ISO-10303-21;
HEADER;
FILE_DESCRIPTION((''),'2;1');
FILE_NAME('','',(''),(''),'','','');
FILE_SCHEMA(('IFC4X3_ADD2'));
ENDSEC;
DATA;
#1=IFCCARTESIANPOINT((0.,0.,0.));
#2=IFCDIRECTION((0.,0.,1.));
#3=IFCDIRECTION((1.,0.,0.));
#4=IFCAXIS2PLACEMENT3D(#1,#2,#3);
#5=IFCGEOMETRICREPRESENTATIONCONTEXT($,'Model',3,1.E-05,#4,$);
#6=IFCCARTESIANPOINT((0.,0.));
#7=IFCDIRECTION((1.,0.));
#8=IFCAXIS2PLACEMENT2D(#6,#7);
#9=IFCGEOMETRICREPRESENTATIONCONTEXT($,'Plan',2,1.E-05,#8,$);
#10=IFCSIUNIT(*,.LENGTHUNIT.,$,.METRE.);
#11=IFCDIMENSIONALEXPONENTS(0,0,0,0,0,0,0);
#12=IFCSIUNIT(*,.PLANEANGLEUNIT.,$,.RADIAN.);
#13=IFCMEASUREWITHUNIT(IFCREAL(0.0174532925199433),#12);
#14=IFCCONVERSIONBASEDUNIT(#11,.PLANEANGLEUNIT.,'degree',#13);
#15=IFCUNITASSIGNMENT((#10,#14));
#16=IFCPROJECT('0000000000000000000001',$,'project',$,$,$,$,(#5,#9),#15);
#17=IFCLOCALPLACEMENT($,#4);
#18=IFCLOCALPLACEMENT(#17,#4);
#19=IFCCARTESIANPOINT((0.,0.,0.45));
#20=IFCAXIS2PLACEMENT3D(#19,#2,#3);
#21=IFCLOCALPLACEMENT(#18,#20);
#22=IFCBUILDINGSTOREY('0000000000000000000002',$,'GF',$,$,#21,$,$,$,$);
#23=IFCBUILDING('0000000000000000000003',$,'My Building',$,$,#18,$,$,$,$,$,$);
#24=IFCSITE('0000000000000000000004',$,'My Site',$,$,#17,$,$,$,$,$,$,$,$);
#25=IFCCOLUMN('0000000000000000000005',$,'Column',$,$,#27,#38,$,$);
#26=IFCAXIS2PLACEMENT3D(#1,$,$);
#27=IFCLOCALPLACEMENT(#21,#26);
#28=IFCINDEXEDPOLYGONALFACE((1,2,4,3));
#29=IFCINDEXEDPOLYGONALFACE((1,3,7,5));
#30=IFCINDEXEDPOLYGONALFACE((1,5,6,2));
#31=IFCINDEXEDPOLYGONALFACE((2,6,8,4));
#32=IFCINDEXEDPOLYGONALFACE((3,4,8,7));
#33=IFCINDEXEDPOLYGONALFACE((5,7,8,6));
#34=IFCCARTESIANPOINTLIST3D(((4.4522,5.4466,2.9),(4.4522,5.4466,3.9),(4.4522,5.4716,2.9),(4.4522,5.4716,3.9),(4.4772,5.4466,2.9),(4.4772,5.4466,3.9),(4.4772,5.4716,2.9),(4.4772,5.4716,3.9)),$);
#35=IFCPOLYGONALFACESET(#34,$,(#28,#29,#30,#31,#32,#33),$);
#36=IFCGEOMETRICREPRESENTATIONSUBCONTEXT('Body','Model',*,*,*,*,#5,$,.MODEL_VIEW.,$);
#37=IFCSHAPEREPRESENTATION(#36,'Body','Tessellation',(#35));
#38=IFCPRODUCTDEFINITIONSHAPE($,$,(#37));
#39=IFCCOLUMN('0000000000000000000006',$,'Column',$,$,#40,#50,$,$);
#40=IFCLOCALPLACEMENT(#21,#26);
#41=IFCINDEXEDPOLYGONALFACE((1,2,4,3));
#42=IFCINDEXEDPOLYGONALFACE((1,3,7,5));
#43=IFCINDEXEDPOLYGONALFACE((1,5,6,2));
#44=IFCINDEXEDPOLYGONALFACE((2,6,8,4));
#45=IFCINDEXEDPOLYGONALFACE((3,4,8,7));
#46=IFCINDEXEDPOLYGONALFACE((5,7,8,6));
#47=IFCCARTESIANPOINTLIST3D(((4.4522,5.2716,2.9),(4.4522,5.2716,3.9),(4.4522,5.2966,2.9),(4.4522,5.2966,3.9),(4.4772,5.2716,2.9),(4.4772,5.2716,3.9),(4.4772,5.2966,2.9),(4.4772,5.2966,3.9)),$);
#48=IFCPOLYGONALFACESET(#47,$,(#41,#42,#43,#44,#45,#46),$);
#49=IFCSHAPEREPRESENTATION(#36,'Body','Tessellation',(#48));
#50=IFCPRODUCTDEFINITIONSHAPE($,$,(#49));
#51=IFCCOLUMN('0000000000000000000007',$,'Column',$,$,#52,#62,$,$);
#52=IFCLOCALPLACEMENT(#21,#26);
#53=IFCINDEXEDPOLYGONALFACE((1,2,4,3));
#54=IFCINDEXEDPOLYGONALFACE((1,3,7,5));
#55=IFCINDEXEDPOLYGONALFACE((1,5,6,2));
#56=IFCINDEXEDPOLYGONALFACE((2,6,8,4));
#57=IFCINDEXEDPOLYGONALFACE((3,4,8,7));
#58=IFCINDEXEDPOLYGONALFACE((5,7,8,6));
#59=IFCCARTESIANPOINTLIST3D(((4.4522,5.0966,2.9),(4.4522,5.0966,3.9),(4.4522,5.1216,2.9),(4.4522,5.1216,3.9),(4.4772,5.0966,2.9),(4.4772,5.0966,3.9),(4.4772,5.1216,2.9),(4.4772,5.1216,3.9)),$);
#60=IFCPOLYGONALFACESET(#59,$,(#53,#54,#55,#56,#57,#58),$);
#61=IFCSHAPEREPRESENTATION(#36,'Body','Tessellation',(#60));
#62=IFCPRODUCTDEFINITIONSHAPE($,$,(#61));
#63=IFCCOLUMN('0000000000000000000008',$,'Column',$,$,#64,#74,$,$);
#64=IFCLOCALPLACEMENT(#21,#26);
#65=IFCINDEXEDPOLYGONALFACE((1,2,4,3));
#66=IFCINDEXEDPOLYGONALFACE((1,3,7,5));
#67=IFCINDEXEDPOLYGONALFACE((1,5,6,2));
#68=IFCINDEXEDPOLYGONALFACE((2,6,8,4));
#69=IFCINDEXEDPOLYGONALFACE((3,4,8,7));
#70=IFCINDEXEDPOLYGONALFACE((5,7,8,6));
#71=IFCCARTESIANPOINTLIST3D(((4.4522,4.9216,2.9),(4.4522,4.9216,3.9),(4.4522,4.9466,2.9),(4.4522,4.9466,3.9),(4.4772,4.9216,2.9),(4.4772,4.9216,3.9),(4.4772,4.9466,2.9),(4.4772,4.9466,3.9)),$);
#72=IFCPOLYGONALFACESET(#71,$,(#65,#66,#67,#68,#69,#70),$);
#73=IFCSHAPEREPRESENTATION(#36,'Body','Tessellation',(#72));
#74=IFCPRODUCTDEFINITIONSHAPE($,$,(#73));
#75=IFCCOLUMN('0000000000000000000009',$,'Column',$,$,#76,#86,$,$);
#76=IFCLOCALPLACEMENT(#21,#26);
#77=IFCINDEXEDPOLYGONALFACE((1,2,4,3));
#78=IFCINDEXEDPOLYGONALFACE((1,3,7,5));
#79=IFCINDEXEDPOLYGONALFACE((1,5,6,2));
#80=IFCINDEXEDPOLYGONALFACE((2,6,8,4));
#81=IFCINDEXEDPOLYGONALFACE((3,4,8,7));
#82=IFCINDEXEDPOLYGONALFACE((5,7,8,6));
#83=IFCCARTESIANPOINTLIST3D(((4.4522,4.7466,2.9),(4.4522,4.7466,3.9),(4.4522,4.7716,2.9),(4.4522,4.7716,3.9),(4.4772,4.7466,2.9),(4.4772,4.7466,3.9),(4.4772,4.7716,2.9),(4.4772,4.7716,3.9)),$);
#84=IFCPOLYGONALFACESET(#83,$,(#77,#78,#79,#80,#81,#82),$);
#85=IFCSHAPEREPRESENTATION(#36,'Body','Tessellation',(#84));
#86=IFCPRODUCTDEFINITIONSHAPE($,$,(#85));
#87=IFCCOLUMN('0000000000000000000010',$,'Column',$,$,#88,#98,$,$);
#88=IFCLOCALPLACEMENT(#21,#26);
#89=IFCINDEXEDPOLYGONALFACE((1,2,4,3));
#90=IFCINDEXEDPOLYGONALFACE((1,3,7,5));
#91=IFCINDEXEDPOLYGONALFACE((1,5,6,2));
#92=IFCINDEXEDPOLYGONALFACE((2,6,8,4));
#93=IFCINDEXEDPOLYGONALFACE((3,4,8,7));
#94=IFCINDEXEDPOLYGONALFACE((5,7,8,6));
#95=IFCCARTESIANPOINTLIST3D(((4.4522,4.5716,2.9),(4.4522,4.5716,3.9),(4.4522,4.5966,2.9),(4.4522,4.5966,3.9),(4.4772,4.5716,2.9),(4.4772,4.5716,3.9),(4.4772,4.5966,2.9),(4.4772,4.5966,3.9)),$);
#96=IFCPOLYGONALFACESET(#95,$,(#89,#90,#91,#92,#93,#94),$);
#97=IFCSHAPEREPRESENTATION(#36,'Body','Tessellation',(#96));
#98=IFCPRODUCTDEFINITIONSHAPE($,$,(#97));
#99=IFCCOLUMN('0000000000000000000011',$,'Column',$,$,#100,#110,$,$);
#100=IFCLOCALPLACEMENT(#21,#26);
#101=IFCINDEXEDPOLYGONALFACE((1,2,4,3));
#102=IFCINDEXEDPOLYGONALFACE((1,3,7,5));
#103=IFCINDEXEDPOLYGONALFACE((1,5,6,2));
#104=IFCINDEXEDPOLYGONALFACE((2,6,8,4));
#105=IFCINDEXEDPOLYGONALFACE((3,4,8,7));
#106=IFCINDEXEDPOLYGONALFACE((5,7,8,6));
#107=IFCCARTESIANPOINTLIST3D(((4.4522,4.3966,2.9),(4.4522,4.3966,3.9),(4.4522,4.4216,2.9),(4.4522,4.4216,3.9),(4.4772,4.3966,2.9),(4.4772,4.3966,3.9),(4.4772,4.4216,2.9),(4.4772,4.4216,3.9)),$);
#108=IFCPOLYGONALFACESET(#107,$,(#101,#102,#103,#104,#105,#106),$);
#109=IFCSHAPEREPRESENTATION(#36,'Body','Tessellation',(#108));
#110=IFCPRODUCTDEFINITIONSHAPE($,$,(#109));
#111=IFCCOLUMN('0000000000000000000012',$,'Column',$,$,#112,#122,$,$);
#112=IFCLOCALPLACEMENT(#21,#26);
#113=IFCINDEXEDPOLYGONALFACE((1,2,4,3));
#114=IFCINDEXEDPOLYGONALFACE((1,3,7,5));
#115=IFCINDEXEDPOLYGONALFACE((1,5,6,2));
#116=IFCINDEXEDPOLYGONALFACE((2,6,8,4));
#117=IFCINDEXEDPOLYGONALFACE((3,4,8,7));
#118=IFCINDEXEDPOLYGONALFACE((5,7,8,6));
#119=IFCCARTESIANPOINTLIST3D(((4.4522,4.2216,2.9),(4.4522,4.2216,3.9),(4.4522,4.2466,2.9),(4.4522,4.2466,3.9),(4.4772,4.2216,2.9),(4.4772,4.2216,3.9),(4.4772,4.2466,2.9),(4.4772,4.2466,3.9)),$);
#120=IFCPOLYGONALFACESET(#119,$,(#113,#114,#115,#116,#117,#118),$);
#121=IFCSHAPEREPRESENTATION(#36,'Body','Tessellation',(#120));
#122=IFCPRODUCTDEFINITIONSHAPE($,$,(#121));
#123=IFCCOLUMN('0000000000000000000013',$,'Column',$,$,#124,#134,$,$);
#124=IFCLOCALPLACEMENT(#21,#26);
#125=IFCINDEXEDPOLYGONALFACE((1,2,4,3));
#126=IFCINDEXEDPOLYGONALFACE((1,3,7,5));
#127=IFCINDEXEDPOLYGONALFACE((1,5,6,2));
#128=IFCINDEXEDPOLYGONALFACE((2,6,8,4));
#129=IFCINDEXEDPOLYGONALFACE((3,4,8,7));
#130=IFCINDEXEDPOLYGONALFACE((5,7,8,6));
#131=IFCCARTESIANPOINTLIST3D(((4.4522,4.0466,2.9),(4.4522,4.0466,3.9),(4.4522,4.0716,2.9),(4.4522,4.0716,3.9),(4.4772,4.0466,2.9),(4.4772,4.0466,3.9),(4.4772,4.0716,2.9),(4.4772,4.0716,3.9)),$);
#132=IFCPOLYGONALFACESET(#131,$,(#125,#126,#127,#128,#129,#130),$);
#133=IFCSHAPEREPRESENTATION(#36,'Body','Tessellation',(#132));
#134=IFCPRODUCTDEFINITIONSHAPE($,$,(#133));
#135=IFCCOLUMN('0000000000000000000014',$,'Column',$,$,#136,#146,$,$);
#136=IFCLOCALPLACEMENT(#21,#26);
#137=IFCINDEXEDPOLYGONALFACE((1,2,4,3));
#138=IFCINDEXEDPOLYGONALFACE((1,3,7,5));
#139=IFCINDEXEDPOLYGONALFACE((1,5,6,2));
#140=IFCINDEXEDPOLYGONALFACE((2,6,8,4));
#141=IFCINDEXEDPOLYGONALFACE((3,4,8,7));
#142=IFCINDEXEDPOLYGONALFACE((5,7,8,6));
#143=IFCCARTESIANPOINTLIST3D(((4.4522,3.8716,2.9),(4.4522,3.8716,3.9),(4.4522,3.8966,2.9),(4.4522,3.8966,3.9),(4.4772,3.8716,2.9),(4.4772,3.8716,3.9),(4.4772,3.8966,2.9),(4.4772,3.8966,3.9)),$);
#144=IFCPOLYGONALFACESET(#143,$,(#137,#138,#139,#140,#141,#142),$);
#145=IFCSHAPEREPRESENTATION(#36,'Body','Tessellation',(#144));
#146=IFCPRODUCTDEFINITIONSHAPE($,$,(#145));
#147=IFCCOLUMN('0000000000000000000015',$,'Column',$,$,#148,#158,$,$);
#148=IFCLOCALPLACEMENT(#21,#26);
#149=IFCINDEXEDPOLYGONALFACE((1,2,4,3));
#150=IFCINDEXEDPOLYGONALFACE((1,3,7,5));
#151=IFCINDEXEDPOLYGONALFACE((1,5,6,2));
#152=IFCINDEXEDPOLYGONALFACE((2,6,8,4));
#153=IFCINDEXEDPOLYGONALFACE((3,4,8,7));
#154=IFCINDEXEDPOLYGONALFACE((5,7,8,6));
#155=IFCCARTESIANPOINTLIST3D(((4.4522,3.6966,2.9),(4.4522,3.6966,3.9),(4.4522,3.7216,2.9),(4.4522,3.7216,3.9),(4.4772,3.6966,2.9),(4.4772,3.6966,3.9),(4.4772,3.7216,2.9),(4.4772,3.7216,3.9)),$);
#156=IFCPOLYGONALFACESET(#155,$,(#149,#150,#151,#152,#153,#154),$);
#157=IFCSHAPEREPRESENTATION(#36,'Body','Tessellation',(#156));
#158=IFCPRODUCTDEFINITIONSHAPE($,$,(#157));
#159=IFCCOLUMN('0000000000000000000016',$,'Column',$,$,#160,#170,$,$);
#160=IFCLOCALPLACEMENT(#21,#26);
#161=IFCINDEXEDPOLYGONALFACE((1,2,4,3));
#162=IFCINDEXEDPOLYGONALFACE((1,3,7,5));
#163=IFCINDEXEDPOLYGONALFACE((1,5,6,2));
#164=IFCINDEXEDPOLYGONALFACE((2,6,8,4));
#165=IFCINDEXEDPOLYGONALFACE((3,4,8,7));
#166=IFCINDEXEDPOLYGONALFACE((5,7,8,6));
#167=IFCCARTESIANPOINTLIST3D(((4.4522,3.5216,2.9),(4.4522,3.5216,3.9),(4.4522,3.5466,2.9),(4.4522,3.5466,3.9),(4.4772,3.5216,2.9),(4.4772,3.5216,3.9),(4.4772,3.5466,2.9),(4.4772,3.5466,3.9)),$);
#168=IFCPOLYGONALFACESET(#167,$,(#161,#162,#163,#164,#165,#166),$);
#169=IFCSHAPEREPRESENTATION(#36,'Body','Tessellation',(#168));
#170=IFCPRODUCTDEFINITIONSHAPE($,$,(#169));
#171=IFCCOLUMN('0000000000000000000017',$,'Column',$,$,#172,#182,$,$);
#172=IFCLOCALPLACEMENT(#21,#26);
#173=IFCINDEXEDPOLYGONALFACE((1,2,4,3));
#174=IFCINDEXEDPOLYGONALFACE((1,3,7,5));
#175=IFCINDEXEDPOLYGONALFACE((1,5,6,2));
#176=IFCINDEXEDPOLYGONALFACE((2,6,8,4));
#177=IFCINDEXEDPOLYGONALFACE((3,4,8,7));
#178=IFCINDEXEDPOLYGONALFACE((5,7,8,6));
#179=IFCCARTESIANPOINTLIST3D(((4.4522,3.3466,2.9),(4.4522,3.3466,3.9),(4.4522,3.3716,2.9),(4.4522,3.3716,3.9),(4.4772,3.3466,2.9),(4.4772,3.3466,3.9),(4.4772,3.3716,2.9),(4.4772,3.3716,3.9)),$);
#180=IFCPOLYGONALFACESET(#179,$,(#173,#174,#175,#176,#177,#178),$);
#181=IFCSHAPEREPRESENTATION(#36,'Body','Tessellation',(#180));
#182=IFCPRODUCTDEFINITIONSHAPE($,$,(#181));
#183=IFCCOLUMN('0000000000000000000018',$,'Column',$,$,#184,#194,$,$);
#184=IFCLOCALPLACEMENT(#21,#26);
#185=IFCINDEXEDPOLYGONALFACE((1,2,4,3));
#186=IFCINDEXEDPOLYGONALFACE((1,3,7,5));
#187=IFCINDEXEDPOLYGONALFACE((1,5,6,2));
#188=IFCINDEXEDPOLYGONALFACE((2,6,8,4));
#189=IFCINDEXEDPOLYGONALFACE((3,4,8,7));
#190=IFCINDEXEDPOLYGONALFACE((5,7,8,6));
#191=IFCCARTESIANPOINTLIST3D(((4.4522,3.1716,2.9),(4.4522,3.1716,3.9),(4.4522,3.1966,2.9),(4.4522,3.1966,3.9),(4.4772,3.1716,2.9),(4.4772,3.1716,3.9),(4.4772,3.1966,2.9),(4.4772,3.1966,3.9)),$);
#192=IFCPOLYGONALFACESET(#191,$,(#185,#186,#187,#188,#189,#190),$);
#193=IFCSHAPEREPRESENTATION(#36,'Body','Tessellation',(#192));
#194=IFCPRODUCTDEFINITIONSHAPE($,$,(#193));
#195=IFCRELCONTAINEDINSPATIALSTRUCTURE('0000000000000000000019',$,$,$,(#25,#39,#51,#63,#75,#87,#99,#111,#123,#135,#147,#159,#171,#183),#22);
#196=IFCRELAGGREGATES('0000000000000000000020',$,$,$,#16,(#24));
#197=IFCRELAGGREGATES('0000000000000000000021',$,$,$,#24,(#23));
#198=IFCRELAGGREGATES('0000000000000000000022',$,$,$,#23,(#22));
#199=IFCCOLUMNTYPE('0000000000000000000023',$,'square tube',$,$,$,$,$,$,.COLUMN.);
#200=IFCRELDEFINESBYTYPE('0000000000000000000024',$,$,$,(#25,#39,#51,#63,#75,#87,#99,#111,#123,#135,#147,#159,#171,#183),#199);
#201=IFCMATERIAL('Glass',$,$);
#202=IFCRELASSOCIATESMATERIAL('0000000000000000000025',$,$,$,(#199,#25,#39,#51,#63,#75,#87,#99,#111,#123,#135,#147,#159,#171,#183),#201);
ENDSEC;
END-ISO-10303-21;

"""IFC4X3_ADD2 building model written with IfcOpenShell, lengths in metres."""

from ifc_helpers import new_model, entity, si_unit, converted_unit, frame, origin_with_axes, origin_2d_with_axis, place, context, subcontext, project, spatial, rectangle, extrude, material, material_profile, profile_set, profile_usage, type_object, element, save


model = new_model("IFC4X3_ADD2")

# Units and contexts
model_context = context("Model", 3, precision=1e-05, world=origin_with_axes())
plan_context = context("Plan", 2, precision=1e-05, world=origin_2d_with_axis())
body_context_1 = subcontext(model_context, "Body", "Model", "MODEL_VIEW")
ifc_project = project(units=[si_unit("LENGTHUNIT", "METRE"), converted_unit("PLANEANGLEUNIT", "degree", entity("IfcReal", 0.0174532925199433), si_unit("PLANEANGLEUNIT", "RADIAN"), dimensions=[0, 0, 0, 0, 0, 0, 0])], contexts=[model_context, plan_context])

# Site, building, storey
site_placement = place(None, origin_with_axes())
site = spatial("IfcSite", under=ifc_project, at=site_placement, Name="My Site")
building_placement = place(site_placement, origin_with_axes())
building = spatial("IfcBuilding", under=site, at=building_placement, Name="My Building")
storey_placement = place(building_placement, frame((0.0, 0.0, 0.45), z_axis=(0.0, 0.0, 1.0), x_axis=(1.0, 0.0, 0.0)))
storey = spatial("IfcBuildingStorey", under=building, at=storey_placement, Name="GF")

# Columns
ifc_material_1 = material(Name="Glass")
ifc_material_profile = material_profile(ifc_material_1, rectangle(XDim=0.025, YDim=0.025))
ifc_profile_set = profile_set([ifc_material_profile])
ifc_profile_usage_1 = profile_usage(ifc_profile_set, cardinal=5)
column_type = type_object("IfcColumnType", Name="square tube", PredefinedType="COLUMN", material=ifc_profile_set)
column_1_placement = place(storey_placement, frame((4.4647, 5.4591, 2.9), z_axis=(0.0, 0.0, 1.0), x_axis=(0.0, -1.0, 0.0)))
element("IfcColumn", 1, at=column_1_placement, inside=storey, type_object=column_type, material=ifc_profile_usage_1, Name="Column", context=body_context_1, shape_type="SweptSolid", body=[
    extrude(rectangle(XDim=0.025, YDim=0.025), origin_with_axes(), (0.0, 0.0, 1.0), 1.0),
])
ifc_profile_usage_2 = profile_usage(ifc_profile_set, cardinal=5)
column_2_placement = place(storey_placement, frame((4.4647, 5.2841, 2.9), z_axis=(0.0, 0.0, 1.0), x_axis=(0.0, -1.0, 0.0)))
element("IfcColumn", 2, at=column_2_placement, inside=storey, type_object=column_type, material=ifc_profile_usage_2, Name="Column", context=body_context_1, shape_type="SweptSolid", body=[
    extrude(rectangle(XDim=0.025, YDim=0.025), origin_with_axes(), (0.0, 0.0, 1.0), 1.0),
])
ifc_profile_usage_3 = profile_usage(ifc_profile_set, cardinal=5)
column_3_placement = place(storey_placement, frame((4.4647, 5.1091, 2.9), z_axis=(0.0, 0.0, 1.0), x_axis=(0.0, -1.0, 0.0)))
element("IfcColumn", 3, at=column_3_placement, inside=storey, type_object=column_type, material=ifc_profile_usage_3, Name="Column", context=body_context_1, shape_type="SweptSolid", body=[
    extrude(rectangle(XDim=0.025, YDim=0.025), origin_with_axes(), (0.0, 0.0, 1.0), 1.0),
])
ifc_profile_usage_4 = profile_usage(ifc_profile_set, cardinal=5)
column_4_placement = place(storey_placement, frame((4.4647, 4.9341, 2.9), z_axis=(0.0, 0.0, 1.0), x_axis=(0.0, -1.0, 0.0)))
element("IfcColumn", 4, at=column_4_placement, inside=storey, type_object=column_type, material=ifc_profile_usage_4, Name="Column", context=body_context_1, shape_type="SweptSolid", body=[
    extrude(rectangle(XDim=0.025, YDim=0.025), origin_with_axes(), (0.0, 0.0, 1.0), 1.0),
])
ifc_profile_usage_5 = profile_usage(ifc_profile_set, cardinal=5)
column_5_placement = place(storey_placement, frame((4.4647, 4.7591, 2.9), z_axis=(0.0, 0.0, 1.0), x_axis=(0.0, -1.0, 0.0)))
element("IfcColumn", 5, at=column_5_placement, inside=storey, type_object=column_type, material=ifc_profile_usage_5, Name="Column", context=body_context_1, shape_type="SweptSolid", body=[
    extrude(rectangle(XDim=0.025, YDim=0.025), origin_with_axes(), (0.0, 0.0, 1.0), 1.0),
])
ifc_profile_usage_6 = profile_usage(ifc_profile_set, cardinal=5)
column_6_placement = place(storey_placement, frame((4.4647, 4.5841, 2.9), z_axis=(0.0, 0.0, 1.0), x_axis=(0.0, -1.0, 0.0)))
element("IfcColumn", 6, at=column_6_placement, inside=storey, type_object=column_type, material=ifc_profile_usage_6, Name="Column", context=body_context_1, shape_type="SweptSolid", body=[
    extrude(rectangle(XDim=0.025, YDim=0.025), origin_with_axes(), (0.0, 0.0, 1.0), 1.0),
])
ifc_profile_usage_7 = profile_usage(ifc_profile_set, cardinal=5)
column_7_placement = place(storey_placement, frame((4.4647, 4.4091, 2.9), z_axis=(0.0, 0.0, 1.0), x_axis=(0.0, -1.0, 0.0)))
element("IfcColumn", 7, at=column_7_placement, inside=storey, type_object=column_type, material=ifc_profile_usage_7, Name="Column", context=body_context_1, shape_type="SweptSolid", body=[
    extrude(rectangle(XDim=0.025, YDim=0.025), origin_with_axes(), (0.0, 0.0, 1.0), 1.0),
])
ifc_profile_usage_8 = profile_usage(ifc_profile_set, cardinal=5)
column_8_placement = place(storey_placement, frame((4.4647, 4.2341, 2.9), z_axis=(0.0, 0.0, 1.0), x_axis=(0.0, -1.0, 0.0)))
element("IfcColumn", 8, at=column_8_placement, inside=storey, type_object=column_type, material=ifc_profile_usage_8, Name="Column", context=body_context_1, shape_type="SweptSolid", body=[
    extrude(rectangle(XDim=0.025, YDim=0.025), origin_with_axes(), (0.0, 0.0, 1.0), 1.0),
])
ifc_profile_usage_9 = profile_usage(ifc_profile_set, cardinal=5)
column_9_placement = place(storey_placement, frame((4.4647, 4.0591, 2.9), z_axis=(0.0, 0.0, 1.0), x_axis=(0.0, -1.0, 0.0)))
element("IfcColumn", 9, at=column_9_placement, inside=storey, type_object=column_type, material=ifc_profile_usage_9, Name="Column", context=body_context_1, shape_type="SweptSolid", body=[
    extrude(rectangle(XDim=0.025, YDim=0.025), origin_with_axes(), (0.0, 0.0, 1.0), 1.0),
])
ifc_profile_usage_10 = profile_usage(ifc_profile_set, cardinal=5)
column_10_placement = place(storey_placement, frame((4.4647, 3.8841, 2.9), z_axis=(0.0, 0.0, 1.0), x_axis=(0.0, -1.0, 0.0)))
element("IfcColumn", 10, at=column_10_placement, inside=storey, type_object=column_type, material=ifc_profile_usage_10, Name="Column", context=body_context_1, shape_type="SweptSolid", body=[
    extrude(rectangle(XDim=0.025, YDim=0.025), origin_with_axes(), (0.0, 0.0, 1.0), 1.0),
])
ifc_profile_usage_11 = profile_usage(ifc_profile_set, cardinal=5)
column_11_placement = place(storey_placement, frame((4.4647, 3.7091, 2.9), z_axis=(0.0, 0.0, 1.0), x_axis=(0.0, -1.0, 0.0)))
element("IfcColumn", 11, at=column_11_placement, inside=storey, type_object=column_type, material=ifc_profile_usage_11, Name="Column", context=body_context_1, shape_type="SweptSolid", body=[
    extrude(rectangle(XDim=0.025, YDim=0.025), origin_with_axes(), (0.0, 0.0, 1.0), 1.0),
])
ifc_profile_usage_12 = profile_usage(ifc_profile_set, cardinal=5)
column_12_placement = place(storey_placement, frame((4.4647, 3.5341, 2.9), z_axis=(0.0, 0.0, 1.0), x_axis=(0.0, -1.0, 0.0)))
element("IfcColumn", 12, at=column_12_placement, inside=storey, type_object=column_type, material=ifc_profile_usage_12, Name="Column", context=body_context_1, shape_type="SweptSolid", body=[
    extrude(rectangle(XDim=0.025, YDim=0.025), origin_with_axes(), (0.0, 0.0, 1.0), 1.0),
])
ifc_profile_usage_13 = profile_usage(ifc_profile_set, cardinal=5)
column_13_placement = place(storey_placement, frame((4.4647, 3.3591, 2.9), z_axis=(0.0, 0.0, 1.0), x_axis=(0.0, -1.0, 0.0)))
element("IfcColumn", 13, at=column_13_placement, inside=storey, type_object=column_type, material=ifc_profile_usage_13, Name="Column", context=body_context_1, shape_type="SweptSolid", body=[
    extrude(rectangle(XDim=0.025, YDim=0.025), origin_with_axes(), (0.0, 0.0, 1.0), 1.0),
])
ifc_profile_usage_14 = profile_usage(ifc_profile_set, cardinal=5)
column_14_placement = place(storey_placement, frame((4.4647, 3.1841, 2.9), z_axis=(0.0, 0.0, 1.0), x_axis=(0.0, -1.0, 0.0)))
element("IfcColumn", 14, at=column_14_placement, inside=storey, type_object=column_type, material=ifc_profile_usage_14, Name="Column", context=body_context_1, shape_type="SweptSolid", body=[
    extrude(rectangle(XDim=0.025, YDim=0.025), origin_with_axes(), (0.0, 0.0, 1.0), 1.0),
])

save(model, "model.ifc")
